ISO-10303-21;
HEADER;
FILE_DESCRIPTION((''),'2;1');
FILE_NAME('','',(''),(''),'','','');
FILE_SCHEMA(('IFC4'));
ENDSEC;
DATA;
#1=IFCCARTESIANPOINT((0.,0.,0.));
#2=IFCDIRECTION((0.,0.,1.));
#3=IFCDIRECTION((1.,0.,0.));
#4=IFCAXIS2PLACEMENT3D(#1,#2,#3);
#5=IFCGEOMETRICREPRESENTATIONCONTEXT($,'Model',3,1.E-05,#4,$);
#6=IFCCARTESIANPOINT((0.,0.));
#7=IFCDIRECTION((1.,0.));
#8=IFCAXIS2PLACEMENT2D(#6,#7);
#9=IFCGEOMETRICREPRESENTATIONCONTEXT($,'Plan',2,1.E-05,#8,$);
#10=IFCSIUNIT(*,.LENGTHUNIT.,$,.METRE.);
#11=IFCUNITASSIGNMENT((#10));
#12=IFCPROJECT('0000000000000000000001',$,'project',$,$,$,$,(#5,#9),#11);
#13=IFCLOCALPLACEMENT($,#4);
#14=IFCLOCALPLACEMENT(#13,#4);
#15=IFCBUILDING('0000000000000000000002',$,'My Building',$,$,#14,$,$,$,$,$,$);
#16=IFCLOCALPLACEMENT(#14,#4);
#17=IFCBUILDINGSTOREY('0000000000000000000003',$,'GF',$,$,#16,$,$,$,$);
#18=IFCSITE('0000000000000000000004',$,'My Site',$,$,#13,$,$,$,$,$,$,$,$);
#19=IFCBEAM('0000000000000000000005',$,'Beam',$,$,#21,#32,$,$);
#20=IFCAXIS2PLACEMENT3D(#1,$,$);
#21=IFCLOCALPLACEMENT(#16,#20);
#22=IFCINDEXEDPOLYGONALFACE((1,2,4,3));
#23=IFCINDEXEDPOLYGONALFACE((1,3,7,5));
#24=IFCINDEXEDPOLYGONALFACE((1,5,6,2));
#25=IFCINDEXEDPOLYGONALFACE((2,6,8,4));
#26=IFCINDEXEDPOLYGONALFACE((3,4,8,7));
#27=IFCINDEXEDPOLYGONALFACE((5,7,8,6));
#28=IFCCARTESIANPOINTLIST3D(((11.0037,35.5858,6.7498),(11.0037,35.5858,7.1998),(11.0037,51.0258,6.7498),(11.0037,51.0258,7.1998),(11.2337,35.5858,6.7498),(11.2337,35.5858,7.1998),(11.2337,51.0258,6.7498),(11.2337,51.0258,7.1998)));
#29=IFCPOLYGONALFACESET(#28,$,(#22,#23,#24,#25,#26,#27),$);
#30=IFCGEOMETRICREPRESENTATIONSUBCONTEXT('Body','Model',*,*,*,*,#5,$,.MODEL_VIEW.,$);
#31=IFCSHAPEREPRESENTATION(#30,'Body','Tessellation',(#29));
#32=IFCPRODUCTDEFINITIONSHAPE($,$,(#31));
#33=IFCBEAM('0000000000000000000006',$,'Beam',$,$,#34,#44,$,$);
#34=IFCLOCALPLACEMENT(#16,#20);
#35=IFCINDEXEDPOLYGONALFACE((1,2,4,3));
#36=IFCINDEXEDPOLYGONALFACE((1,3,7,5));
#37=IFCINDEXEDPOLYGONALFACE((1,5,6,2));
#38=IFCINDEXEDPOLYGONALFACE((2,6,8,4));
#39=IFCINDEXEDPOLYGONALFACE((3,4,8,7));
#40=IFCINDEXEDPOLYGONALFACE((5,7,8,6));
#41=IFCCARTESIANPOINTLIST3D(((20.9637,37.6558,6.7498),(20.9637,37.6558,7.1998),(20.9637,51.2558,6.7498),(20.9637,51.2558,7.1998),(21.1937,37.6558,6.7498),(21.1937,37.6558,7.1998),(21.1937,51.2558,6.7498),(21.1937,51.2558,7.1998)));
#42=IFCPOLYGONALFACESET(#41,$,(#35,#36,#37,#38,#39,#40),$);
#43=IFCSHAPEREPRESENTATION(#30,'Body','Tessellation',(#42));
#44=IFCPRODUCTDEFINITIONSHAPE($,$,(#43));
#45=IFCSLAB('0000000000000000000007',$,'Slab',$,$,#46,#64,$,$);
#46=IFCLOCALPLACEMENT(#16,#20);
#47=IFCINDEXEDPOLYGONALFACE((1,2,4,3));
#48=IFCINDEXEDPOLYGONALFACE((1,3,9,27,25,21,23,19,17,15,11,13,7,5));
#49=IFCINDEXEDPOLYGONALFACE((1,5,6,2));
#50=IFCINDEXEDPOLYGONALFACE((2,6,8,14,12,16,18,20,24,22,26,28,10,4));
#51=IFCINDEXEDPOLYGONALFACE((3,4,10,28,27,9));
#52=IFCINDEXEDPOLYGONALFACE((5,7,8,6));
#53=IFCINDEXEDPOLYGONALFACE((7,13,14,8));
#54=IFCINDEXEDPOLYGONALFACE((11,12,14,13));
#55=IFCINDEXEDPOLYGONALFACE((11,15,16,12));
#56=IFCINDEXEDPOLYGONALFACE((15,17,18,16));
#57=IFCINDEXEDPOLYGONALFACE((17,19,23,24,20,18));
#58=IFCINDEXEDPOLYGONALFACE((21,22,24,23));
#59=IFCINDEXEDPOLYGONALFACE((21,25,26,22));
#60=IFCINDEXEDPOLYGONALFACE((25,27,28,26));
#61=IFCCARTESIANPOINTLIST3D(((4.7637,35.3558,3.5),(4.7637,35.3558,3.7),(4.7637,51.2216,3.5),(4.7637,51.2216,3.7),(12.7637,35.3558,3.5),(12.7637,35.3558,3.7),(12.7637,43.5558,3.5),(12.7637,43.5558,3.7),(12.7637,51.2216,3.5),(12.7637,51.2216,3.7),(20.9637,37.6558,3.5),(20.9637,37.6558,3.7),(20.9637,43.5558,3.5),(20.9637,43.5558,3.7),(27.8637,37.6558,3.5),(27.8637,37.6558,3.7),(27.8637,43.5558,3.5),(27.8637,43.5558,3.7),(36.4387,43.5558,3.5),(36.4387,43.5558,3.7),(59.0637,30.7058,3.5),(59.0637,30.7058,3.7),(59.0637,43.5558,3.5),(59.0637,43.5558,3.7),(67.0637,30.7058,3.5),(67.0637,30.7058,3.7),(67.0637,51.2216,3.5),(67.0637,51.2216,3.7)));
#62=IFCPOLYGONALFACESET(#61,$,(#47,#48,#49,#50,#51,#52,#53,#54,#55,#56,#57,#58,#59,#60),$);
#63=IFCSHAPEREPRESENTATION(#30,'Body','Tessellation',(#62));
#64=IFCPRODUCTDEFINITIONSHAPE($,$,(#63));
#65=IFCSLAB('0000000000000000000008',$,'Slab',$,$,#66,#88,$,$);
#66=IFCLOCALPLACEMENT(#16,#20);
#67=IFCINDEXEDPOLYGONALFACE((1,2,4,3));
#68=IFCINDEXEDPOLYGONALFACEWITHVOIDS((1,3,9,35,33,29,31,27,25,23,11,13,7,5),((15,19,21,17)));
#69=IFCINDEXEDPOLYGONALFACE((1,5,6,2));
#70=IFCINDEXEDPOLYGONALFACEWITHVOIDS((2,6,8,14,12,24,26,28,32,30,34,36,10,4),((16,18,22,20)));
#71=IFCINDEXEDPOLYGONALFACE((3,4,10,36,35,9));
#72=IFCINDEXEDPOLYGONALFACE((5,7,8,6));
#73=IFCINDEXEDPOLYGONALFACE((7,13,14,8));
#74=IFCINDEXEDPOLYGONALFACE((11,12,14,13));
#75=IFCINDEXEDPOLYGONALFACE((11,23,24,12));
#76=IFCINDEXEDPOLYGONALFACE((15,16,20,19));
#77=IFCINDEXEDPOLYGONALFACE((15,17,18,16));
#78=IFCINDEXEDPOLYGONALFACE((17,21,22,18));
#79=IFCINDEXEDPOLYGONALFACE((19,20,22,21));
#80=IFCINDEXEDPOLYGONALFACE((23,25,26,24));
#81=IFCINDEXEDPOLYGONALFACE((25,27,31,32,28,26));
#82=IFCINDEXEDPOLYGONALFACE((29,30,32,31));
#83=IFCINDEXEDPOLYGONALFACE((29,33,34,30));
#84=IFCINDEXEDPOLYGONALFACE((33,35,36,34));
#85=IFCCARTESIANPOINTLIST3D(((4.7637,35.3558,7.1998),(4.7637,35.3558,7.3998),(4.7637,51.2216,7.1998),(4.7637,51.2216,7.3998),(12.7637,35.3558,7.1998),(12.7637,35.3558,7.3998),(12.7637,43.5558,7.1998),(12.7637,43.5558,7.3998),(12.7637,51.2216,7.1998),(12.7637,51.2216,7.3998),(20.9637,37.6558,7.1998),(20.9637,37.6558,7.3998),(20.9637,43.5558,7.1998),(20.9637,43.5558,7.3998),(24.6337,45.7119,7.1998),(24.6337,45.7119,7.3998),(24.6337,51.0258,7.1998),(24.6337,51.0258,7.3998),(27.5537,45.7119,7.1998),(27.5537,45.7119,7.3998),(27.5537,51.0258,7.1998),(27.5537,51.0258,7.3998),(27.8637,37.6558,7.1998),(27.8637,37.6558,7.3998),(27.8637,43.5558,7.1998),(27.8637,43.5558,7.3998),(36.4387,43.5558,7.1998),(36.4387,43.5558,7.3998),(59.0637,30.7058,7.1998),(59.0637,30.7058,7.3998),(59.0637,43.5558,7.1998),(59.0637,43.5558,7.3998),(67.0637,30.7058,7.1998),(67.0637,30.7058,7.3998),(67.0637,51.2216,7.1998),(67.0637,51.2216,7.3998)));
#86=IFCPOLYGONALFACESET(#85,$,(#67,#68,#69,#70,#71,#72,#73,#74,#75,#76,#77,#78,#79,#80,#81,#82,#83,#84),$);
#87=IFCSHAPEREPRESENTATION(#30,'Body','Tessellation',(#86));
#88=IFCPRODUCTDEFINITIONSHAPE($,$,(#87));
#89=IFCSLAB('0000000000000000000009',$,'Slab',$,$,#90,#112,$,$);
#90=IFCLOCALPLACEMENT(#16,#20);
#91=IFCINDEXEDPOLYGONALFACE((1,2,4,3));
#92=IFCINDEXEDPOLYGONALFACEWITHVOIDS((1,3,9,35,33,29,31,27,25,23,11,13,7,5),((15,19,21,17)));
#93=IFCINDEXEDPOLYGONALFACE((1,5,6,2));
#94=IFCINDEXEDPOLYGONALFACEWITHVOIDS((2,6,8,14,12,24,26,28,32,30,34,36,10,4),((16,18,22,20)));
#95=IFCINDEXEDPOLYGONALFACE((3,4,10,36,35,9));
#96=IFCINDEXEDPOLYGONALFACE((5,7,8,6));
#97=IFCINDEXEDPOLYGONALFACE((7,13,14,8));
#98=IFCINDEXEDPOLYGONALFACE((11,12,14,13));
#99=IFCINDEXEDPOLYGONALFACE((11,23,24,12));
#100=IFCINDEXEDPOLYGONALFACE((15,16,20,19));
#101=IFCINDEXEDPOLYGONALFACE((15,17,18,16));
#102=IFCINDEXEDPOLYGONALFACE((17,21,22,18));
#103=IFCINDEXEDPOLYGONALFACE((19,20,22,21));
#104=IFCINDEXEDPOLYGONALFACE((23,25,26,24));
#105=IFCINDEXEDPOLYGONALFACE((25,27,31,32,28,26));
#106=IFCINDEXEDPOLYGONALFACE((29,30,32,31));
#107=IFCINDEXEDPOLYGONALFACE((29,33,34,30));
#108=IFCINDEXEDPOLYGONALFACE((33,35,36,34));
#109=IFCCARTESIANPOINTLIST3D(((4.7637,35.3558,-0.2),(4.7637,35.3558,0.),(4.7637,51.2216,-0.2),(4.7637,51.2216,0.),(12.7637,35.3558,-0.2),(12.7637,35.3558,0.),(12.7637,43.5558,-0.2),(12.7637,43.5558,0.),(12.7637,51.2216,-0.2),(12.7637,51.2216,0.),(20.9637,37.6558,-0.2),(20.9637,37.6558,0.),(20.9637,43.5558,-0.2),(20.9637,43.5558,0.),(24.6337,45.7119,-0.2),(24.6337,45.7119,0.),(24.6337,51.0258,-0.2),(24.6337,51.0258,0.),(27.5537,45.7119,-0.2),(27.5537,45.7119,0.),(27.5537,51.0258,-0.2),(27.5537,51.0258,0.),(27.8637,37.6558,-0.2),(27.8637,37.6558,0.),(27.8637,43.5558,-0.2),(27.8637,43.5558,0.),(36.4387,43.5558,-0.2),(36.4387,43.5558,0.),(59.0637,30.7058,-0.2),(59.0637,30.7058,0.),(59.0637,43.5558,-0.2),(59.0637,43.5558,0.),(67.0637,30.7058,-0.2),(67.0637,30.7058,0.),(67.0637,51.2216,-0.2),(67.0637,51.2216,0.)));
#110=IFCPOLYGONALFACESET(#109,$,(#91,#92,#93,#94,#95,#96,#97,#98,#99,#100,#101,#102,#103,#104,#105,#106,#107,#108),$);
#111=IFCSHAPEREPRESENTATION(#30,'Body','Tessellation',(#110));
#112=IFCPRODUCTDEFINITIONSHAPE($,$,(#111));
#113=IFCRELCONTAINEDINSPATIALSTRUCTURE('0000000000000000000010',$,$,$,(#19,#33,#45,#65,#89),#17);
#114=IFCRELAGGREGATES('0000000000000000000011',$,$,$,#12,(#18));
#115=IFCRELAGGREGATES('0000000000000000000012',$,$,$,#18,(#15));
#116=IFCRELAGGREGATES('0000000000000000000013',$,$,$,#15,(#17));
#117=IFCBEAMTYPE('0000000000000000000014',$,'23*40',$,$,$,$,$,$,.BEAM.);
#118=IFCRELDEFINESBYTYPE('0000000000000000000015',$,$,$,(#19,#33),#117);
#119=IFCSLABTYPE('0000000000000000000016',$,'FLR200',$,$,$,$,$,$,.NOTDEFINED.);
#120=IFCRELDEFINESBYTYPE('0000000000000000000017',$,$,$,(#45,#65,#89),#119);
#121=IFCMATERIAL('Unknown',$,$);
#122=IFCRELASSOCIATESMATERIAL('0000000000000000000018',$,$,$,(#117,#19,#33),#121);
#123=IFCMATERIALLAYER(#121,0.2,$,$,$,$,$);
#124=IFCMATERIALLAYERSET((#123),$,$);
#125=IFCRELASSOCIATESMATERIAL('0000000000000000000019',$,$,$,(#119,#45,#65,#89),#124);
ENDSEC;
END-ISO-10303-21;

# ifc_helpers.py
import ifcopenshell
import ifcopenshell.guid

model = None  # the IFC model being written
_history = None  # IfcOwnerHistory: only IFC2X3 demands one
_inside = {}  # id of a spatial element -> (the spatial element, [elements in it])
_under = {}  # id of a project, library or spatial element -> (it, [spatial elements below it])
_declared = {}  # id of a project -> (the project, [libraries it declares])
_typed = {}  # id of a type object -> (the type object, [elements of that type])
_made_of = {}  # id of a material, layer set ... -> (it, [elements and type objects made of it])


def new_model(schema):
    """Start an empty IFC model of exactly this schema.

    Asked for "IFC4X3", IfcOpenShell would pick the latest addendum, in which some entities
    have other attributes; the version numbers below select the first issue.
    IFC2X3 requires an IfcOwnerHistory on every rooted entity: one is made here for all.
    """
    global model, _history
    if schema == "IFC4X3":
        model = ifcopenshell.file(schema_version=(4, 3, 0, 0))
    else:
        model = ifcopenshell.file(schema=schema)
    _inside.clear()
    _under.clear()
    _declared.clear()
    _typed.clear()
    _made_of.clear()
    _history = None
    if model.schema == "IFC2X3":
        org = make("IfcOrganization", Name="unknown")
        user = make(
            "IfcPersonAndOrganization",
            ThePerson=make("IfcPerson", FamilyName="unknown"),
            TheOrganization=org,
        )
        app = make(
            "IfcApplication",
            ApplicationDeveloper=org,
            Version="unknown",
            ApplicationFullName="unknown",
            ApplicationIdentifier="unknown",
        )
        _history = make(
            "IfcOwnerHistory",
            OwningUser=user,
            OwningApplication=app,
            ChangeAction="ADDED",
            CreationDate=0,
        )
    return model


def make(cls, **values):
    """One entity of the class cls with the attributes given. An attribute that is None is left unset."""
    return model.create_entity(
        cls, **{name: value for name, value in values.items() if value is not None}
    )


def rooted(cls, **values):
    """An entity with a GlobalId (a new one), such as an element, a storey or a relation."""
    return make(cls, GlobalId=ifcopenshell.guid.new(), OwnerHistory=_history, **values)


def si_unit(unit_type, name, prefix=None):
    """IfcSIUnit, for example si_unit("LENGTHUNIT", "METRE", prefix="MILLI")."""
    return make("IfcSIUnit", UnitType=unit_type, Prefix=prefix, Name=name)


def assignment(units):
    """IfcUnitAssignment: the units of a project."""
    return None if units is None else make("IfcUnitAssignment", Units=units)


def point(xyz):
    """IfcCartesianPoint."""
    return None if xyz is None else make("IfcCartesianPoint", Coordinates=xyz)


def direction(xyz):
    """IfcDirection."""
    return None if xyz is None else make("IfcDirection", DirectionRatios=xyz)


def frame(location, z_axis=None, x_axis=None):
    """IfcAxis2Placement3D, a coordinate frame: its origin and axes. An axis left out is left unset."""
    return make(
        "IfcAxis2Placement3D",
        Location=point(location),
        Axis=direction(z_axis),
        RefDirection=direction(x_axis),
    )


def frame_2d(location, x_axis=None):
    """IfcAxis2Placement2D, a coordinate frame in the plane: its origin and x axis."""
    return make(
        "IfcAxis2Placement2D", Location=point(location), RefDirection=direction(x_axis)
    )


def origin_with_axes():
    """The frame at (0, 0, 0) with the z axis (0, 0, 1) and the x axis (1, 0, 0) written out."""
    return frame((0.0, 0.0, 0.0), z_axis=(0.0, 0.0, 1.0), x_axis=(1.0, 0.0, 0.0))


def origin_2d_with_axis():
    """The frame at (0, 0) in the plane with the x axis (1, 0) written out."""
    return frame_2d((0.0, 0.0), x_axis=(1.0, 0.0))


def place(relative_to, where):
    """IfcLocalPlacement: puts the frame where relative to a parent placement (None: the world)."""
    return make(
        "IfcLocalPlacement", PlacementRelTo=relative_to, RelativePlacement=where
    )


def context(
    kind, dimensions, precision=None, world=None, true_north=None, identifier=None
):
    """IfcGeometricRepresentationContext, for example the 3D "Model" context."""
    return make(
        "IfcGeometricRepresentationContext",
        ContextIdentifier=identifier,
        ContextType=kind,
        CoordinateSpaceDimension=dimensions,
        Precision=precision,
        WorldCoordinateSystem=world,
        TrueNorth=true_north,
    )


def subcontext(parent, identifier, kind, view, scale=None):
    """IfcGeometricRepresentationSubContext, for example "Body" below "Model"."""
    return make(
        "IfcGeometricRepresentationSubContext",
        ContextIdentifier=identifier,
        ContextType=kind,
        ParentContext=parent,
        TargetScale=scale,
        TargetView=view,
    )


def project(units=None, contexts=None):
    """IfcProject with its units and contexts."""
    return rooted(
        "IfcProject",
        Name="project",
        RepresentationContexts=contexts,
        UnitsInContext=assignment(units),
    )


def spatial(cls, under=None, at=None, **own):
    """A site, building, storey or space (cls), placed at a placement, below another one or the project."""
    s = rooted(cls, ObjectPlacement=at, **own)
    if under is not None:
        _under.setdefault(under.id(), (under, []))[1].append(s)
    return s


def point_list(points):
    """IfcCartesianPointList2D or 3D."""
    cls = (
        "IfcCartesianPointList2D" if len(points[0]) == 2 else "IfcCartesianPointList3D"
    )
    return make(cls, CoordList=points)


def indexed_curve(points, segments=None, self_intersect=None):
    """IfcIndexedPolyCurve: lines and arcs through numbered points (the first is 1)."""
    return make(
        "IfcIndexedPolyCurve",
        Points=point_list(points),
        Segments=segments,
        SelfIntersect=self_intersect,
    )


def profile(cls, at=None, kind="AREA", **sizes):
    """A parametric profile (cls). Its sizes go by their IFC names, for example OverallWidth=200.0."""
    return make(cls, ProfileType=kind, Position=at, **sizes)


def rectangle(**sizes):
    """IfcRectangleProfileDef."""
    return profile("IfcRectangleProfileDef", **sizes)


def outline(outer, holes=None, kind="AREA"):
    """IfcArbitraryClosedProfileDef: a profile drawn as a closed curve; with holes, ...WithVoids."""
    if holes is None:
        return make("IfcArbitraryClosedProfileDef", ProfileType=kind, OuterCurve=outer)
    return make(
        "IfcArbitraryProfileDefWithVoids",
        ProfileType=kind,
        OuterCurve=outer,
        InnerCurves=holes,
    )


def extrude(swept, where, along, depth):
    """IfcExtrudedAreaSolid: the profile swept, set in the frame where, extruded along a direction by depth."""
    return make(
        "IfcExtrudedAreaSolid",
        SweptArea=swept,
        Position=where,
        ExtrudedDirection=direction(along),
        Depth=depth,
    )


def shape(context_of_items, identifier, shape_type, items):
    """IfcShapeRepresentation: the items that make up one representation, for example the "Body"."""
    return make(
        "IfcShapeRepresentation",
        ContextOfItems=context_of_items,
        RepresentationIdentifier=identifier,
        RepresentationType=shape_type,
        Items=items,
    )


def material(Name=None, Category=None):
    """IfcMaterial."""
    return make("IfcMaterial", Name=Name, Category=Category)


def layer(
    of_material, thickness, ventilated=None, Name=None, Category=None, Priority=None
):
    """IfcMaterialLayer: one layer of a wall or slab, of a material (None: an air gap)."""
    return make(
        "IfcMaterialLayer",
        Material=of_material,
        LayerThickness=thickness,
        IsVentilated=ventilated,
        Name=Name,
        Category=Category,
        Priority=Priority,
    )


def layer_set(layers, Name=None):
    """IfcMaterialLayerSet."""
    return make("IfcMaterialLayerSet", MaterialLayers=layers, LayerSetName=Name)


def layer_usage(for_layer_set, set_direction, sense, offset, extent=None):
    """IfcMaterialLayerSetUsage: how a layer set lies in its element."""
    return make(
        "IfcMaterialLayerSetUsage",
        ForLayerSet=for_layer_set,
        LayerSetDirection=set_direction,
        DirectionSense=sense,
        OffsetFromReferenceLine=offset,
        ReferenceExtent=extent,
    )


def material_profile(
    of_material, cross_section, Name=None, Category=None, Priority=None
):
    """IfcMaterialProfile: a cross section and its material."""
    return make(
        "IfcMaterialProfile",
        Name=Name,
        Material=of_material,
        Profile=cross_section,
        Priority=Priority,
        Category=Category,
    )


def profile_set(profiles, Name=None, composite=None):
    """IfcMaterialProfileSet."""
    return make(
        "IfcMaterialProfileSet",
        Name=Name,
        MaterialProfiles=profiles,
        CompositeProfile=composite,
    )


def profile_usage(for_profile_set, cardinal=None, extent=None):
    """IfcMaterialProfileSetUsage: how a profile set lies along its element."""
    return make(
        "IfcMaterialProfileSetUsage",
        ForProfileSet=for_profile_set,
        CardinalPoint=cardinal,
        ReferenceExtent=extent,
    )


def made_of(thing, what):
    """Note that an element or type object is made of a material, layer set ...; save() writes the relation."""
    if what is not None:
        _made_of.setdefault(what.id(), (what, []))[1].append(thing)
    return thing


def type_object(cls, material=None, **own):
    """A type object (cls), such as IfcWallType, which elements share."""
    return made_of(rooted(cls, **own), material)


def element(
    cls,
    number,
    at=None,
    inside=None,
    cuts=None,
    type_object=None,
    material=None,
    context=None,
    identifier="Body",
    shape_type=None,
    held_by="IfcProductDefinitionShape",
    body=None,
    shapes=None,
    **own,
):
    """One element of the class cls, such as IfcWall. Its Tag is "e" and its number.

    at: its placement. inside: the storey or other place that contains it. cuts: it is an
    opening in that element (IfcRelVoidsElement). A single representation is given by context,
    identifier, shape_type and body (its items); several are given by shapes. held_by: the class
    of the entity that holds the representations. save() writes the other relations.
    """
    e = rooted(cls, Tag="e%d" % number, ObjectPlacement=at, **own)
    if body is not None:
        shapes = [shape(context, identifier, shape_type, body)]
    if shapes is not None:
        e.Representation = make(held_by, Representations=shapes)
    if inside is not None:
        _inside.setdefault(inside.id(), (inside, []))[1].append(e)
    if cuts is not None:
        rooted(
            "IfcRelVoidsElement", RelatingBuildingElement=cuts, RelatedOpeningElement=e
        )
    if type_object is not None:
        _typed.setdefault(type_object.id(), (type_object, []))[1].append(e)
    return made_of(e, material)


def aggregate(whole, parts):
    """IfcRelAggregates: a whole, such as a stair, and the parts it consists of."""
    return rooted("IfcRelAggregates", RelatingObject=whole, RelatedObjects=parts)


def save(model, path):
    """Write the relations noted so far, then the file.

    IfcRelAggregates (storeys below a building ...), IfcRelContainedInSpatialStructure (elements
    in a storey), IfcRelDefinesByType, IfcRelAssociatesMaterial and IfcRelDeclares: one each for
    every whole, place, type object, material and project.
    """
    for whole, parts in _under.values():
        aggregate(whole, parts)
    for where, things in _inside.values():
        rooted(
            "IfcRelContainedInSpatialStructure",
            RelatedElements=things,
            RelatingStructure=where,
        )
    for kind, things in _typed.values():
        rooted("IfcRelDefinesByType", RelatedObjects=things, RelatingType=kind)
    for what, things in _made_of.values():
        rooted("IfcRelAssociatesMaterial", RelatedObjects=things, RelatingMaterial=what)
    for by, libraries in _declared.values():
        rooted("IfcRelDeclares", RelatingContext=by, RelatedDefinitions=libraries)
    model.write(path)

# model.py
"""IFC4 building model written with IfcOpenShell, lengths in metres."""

from ifc_helpers import new_model, si_unit, frame, origin_with_axes, origin_2d_with_axis, place, context, subcontext, project, spatial, indexed_curve, rectangle, outline, extrude, material, layer, layer_set, layer_usage, material_profile, profile_set, profile_usage, type_object, element, save


model = new_model("IFC4")

# Units and contexts
model_context = context("Model", 3, precision=1e-05, world=origin_with_axes())
plan_context = context("Plan", 2, precision=1e-05, world=origin_2d_with_axis())
body_context = subcontext(model_context, "Body", "Model", "MODEL_VIEW")
ifc_project = project(units=[si_unit("LENGTHUNIT", "METRE")], contexts=[model_context, plan_context])

# Site, building, storey
site_placement = place(None, origin_with_axes())
site = spatial("IfcSite", under=ifc_project, at=site_placement, Name="My Site")
building_placement = place(site_placement, origin_with_axes())
building = spatial("IfcBuilding", under=site, at=building_placement, Name="My Building")
storey_placement = place(building_placement, origin_with_axes())
storey = spatial("IfcBuildingStorey", under=building, at=storey_placement, Name="GF")

# Shared definitions
ifc_material = material(Name="Unknown")

# Beams
ifc_material_profile_1 = material_profile(ifc_material, rectangle(XDim=0.23, YDim=0.45))
ifc_profile_set_1 = profile_set([ifc_material_profile_1])
beam_type = type_object("IfcBeamType", Name="23*40", PredefinedType="BEAM", material=ifc_profile_set_1)
ifc_profile_usage_1 = profile_usage(ifc_profile_set_1, cardinal=5)
beam_1_placement = place(storey_placement, frame((11.1187, 35.5858, 6.9748), z_axis=(0.0, 1.0, 0.0), x_axis=(-1.0, 0.0, 0.0)))
element("IfcBeam", 1, at=beam_1_placement, inside=storey, type_object=beam_type, material=ifc_profile_usage_1, Name="Beam", context=body_context, shape_type="SweptSolid", body=[
    extrude(rectangle(XDim=0.23, YDim=0.45), origin_with_axes(), (0.0, 0.0, 1.0), 15.44),
])
ifc_profile_usage_2 = profile_usage(ifc_profile_set_1, cardinal=5)
beam_2_placement = place(storey_placement, frame((21.0787, 37.6558, 6.9748), z_axis=(0.0, 1.0, 0.0), x_axis=(-1.0, 0.0, 0.0)))
element("IfcBeam", 2, at=beam_2_placement, inside=storey, type_object=beam_type, material=ifc_profile_usage_2, Name="Beam", context=body_context, shape_type="SweptSolid", body=[
    extrude(rectangle(XDim=0.23, YDim=0.45), origin_with_axes(), (0.0, 0.0, 1.0), 13.6),
])

# Slabs
ifc_layer = layer(ifc_material, 0.2)
ifc_layer_set = layer_set([ifc_layer])
ifc_layer_usage_1 = layer_usage(ifc_layer_set, "AXIS3", "POSITIVE", -0.2)
slab_type = type_object("IfcSlabType", Name="FLR200", PredefinedType="NOTDEFINED", material=ifc_layer_set)
slab_1_placement = place(storey_placement, frame((4.7637, 35.3558, 3.7), z_axis=(0.0, 0.0, 1.0), x_axis=(1.0, 0.0, 0.0)))
element("IfcSlab", 3, at=slab_1_placement, inside=storey, type_object=slab_type, material=ifc_layer_usage_1, Name="Slab", context=body_context, shape_type="SweptSolid", body=[
    extrude(outline(indexed_curve([(16.2, 8.2), (16.2, 2.3), (23.1, 2.3), (23.1, 8.2), (31.675, 8.2), (54.3, 8.2), (54.3, -4.65), (62.3, -4.65), (62.3, 15.8657), (8.0, 15.8657), (0.0, 15.8657), (0.0, 0.0), (8.0, 0.0), (8.0, 8.2), (16.2, 8.2)])), frame((0.0, 0.0, -0.2), z_axis=(0.0, 0.0, 1.0), x_axis=(1.0, 0.0, 0.0)), (0.0, 0.0, 1.0), 0.2),
])
ifc_layer_usage_2 = layer_usage(ifc_layer_set, "AXIS3", "POSITIVE", -0.2)
slab_2_placement = place(storey_placement, frame((4.7637, 35.3558, 7.3998), z_axis=(0.0, 0.0, 1.0), x_axis=(1.0, 0.0, 0.0)))
element("IfcSlab", 4, at=slab_2_placement, inside=storey, type_object=slab_type, material=ifc_layer_usage_2, Name="Slab", context=body_context, shape_type="SweptSolid", body=[
    extrude(outline(indexed_curve([(16.2, 8.2), (16.2, 2.3), (23.1, 2.3), (23.1, 8.2), (31.675, 8.2), (54.3, 8.2), (54.3, -4.65), (62.3, -4.65), (62.3, 15.8657), (8.0, 15.8657), (0.0, 15.8657), (0.0, 0.0), (8.0, 0.0), (8.0, 8.2), (16.2, 8.2)]), holes=[indexed_curve([(19.87, 15.67), (19.87, 10.3561), (22.79, 10.3561), (22.79, 15.67), (19.87, 15.67)])]), frame((0.0, 0.0, -0.2), z_axis=(0.0, 0.0, 1.0), x_axis=(1.0, 0.0, 0.0)), (0.0, 0.0, 1.0), 0.2),
])
ifc_layer_usage_3 = layer_usage(ifc_layer_set, "AXIS3", "POSITIVE", -0.2)
slab_3_placement = place(storey_placement, frame((4.7637, 35.3558, 0.0), z_axis=(0.0, 0.0, 1.0), x_axis=(1.0, 0.0, 0.0)))
element("IfcSlab", 5, at=slab_3_placement, inside=storey, type_object=slab_type, material=ifc_layer_usage_3, Name="Slab", context=body_context, shape_type="SweptSolid", body=[
    extrude(outline(indexed_curve([(8.0, 8.2), (8.0, 0.0), (0.0, 0.0), (0.0, 15.8657), (8.0, 15.8657), (62.3, 15.8657), (62.3, -4.65), (54.3, -4.65), (54.3, 8.2), (31.675, 8.2), (23.1, 8.2), (23.1, 2.3), (16.2, 2.3), (16.2, 8.2), (8.0, 8.2)]), holes=[indexed_curve([(22.79, 15.67), (22.79, 10.3561), (19.87, 10.3561), (19.87, 15.67), (22.79, 15.67)])]), frame((0.0, 0.0, -0.2), z_axis=(0.0, 0.0, 1.0), x_axis=(1.0, 0.0, 0.0)), (0.0, 0.0, 1.0), 0.2),
])

save(model, "model.ifc")
